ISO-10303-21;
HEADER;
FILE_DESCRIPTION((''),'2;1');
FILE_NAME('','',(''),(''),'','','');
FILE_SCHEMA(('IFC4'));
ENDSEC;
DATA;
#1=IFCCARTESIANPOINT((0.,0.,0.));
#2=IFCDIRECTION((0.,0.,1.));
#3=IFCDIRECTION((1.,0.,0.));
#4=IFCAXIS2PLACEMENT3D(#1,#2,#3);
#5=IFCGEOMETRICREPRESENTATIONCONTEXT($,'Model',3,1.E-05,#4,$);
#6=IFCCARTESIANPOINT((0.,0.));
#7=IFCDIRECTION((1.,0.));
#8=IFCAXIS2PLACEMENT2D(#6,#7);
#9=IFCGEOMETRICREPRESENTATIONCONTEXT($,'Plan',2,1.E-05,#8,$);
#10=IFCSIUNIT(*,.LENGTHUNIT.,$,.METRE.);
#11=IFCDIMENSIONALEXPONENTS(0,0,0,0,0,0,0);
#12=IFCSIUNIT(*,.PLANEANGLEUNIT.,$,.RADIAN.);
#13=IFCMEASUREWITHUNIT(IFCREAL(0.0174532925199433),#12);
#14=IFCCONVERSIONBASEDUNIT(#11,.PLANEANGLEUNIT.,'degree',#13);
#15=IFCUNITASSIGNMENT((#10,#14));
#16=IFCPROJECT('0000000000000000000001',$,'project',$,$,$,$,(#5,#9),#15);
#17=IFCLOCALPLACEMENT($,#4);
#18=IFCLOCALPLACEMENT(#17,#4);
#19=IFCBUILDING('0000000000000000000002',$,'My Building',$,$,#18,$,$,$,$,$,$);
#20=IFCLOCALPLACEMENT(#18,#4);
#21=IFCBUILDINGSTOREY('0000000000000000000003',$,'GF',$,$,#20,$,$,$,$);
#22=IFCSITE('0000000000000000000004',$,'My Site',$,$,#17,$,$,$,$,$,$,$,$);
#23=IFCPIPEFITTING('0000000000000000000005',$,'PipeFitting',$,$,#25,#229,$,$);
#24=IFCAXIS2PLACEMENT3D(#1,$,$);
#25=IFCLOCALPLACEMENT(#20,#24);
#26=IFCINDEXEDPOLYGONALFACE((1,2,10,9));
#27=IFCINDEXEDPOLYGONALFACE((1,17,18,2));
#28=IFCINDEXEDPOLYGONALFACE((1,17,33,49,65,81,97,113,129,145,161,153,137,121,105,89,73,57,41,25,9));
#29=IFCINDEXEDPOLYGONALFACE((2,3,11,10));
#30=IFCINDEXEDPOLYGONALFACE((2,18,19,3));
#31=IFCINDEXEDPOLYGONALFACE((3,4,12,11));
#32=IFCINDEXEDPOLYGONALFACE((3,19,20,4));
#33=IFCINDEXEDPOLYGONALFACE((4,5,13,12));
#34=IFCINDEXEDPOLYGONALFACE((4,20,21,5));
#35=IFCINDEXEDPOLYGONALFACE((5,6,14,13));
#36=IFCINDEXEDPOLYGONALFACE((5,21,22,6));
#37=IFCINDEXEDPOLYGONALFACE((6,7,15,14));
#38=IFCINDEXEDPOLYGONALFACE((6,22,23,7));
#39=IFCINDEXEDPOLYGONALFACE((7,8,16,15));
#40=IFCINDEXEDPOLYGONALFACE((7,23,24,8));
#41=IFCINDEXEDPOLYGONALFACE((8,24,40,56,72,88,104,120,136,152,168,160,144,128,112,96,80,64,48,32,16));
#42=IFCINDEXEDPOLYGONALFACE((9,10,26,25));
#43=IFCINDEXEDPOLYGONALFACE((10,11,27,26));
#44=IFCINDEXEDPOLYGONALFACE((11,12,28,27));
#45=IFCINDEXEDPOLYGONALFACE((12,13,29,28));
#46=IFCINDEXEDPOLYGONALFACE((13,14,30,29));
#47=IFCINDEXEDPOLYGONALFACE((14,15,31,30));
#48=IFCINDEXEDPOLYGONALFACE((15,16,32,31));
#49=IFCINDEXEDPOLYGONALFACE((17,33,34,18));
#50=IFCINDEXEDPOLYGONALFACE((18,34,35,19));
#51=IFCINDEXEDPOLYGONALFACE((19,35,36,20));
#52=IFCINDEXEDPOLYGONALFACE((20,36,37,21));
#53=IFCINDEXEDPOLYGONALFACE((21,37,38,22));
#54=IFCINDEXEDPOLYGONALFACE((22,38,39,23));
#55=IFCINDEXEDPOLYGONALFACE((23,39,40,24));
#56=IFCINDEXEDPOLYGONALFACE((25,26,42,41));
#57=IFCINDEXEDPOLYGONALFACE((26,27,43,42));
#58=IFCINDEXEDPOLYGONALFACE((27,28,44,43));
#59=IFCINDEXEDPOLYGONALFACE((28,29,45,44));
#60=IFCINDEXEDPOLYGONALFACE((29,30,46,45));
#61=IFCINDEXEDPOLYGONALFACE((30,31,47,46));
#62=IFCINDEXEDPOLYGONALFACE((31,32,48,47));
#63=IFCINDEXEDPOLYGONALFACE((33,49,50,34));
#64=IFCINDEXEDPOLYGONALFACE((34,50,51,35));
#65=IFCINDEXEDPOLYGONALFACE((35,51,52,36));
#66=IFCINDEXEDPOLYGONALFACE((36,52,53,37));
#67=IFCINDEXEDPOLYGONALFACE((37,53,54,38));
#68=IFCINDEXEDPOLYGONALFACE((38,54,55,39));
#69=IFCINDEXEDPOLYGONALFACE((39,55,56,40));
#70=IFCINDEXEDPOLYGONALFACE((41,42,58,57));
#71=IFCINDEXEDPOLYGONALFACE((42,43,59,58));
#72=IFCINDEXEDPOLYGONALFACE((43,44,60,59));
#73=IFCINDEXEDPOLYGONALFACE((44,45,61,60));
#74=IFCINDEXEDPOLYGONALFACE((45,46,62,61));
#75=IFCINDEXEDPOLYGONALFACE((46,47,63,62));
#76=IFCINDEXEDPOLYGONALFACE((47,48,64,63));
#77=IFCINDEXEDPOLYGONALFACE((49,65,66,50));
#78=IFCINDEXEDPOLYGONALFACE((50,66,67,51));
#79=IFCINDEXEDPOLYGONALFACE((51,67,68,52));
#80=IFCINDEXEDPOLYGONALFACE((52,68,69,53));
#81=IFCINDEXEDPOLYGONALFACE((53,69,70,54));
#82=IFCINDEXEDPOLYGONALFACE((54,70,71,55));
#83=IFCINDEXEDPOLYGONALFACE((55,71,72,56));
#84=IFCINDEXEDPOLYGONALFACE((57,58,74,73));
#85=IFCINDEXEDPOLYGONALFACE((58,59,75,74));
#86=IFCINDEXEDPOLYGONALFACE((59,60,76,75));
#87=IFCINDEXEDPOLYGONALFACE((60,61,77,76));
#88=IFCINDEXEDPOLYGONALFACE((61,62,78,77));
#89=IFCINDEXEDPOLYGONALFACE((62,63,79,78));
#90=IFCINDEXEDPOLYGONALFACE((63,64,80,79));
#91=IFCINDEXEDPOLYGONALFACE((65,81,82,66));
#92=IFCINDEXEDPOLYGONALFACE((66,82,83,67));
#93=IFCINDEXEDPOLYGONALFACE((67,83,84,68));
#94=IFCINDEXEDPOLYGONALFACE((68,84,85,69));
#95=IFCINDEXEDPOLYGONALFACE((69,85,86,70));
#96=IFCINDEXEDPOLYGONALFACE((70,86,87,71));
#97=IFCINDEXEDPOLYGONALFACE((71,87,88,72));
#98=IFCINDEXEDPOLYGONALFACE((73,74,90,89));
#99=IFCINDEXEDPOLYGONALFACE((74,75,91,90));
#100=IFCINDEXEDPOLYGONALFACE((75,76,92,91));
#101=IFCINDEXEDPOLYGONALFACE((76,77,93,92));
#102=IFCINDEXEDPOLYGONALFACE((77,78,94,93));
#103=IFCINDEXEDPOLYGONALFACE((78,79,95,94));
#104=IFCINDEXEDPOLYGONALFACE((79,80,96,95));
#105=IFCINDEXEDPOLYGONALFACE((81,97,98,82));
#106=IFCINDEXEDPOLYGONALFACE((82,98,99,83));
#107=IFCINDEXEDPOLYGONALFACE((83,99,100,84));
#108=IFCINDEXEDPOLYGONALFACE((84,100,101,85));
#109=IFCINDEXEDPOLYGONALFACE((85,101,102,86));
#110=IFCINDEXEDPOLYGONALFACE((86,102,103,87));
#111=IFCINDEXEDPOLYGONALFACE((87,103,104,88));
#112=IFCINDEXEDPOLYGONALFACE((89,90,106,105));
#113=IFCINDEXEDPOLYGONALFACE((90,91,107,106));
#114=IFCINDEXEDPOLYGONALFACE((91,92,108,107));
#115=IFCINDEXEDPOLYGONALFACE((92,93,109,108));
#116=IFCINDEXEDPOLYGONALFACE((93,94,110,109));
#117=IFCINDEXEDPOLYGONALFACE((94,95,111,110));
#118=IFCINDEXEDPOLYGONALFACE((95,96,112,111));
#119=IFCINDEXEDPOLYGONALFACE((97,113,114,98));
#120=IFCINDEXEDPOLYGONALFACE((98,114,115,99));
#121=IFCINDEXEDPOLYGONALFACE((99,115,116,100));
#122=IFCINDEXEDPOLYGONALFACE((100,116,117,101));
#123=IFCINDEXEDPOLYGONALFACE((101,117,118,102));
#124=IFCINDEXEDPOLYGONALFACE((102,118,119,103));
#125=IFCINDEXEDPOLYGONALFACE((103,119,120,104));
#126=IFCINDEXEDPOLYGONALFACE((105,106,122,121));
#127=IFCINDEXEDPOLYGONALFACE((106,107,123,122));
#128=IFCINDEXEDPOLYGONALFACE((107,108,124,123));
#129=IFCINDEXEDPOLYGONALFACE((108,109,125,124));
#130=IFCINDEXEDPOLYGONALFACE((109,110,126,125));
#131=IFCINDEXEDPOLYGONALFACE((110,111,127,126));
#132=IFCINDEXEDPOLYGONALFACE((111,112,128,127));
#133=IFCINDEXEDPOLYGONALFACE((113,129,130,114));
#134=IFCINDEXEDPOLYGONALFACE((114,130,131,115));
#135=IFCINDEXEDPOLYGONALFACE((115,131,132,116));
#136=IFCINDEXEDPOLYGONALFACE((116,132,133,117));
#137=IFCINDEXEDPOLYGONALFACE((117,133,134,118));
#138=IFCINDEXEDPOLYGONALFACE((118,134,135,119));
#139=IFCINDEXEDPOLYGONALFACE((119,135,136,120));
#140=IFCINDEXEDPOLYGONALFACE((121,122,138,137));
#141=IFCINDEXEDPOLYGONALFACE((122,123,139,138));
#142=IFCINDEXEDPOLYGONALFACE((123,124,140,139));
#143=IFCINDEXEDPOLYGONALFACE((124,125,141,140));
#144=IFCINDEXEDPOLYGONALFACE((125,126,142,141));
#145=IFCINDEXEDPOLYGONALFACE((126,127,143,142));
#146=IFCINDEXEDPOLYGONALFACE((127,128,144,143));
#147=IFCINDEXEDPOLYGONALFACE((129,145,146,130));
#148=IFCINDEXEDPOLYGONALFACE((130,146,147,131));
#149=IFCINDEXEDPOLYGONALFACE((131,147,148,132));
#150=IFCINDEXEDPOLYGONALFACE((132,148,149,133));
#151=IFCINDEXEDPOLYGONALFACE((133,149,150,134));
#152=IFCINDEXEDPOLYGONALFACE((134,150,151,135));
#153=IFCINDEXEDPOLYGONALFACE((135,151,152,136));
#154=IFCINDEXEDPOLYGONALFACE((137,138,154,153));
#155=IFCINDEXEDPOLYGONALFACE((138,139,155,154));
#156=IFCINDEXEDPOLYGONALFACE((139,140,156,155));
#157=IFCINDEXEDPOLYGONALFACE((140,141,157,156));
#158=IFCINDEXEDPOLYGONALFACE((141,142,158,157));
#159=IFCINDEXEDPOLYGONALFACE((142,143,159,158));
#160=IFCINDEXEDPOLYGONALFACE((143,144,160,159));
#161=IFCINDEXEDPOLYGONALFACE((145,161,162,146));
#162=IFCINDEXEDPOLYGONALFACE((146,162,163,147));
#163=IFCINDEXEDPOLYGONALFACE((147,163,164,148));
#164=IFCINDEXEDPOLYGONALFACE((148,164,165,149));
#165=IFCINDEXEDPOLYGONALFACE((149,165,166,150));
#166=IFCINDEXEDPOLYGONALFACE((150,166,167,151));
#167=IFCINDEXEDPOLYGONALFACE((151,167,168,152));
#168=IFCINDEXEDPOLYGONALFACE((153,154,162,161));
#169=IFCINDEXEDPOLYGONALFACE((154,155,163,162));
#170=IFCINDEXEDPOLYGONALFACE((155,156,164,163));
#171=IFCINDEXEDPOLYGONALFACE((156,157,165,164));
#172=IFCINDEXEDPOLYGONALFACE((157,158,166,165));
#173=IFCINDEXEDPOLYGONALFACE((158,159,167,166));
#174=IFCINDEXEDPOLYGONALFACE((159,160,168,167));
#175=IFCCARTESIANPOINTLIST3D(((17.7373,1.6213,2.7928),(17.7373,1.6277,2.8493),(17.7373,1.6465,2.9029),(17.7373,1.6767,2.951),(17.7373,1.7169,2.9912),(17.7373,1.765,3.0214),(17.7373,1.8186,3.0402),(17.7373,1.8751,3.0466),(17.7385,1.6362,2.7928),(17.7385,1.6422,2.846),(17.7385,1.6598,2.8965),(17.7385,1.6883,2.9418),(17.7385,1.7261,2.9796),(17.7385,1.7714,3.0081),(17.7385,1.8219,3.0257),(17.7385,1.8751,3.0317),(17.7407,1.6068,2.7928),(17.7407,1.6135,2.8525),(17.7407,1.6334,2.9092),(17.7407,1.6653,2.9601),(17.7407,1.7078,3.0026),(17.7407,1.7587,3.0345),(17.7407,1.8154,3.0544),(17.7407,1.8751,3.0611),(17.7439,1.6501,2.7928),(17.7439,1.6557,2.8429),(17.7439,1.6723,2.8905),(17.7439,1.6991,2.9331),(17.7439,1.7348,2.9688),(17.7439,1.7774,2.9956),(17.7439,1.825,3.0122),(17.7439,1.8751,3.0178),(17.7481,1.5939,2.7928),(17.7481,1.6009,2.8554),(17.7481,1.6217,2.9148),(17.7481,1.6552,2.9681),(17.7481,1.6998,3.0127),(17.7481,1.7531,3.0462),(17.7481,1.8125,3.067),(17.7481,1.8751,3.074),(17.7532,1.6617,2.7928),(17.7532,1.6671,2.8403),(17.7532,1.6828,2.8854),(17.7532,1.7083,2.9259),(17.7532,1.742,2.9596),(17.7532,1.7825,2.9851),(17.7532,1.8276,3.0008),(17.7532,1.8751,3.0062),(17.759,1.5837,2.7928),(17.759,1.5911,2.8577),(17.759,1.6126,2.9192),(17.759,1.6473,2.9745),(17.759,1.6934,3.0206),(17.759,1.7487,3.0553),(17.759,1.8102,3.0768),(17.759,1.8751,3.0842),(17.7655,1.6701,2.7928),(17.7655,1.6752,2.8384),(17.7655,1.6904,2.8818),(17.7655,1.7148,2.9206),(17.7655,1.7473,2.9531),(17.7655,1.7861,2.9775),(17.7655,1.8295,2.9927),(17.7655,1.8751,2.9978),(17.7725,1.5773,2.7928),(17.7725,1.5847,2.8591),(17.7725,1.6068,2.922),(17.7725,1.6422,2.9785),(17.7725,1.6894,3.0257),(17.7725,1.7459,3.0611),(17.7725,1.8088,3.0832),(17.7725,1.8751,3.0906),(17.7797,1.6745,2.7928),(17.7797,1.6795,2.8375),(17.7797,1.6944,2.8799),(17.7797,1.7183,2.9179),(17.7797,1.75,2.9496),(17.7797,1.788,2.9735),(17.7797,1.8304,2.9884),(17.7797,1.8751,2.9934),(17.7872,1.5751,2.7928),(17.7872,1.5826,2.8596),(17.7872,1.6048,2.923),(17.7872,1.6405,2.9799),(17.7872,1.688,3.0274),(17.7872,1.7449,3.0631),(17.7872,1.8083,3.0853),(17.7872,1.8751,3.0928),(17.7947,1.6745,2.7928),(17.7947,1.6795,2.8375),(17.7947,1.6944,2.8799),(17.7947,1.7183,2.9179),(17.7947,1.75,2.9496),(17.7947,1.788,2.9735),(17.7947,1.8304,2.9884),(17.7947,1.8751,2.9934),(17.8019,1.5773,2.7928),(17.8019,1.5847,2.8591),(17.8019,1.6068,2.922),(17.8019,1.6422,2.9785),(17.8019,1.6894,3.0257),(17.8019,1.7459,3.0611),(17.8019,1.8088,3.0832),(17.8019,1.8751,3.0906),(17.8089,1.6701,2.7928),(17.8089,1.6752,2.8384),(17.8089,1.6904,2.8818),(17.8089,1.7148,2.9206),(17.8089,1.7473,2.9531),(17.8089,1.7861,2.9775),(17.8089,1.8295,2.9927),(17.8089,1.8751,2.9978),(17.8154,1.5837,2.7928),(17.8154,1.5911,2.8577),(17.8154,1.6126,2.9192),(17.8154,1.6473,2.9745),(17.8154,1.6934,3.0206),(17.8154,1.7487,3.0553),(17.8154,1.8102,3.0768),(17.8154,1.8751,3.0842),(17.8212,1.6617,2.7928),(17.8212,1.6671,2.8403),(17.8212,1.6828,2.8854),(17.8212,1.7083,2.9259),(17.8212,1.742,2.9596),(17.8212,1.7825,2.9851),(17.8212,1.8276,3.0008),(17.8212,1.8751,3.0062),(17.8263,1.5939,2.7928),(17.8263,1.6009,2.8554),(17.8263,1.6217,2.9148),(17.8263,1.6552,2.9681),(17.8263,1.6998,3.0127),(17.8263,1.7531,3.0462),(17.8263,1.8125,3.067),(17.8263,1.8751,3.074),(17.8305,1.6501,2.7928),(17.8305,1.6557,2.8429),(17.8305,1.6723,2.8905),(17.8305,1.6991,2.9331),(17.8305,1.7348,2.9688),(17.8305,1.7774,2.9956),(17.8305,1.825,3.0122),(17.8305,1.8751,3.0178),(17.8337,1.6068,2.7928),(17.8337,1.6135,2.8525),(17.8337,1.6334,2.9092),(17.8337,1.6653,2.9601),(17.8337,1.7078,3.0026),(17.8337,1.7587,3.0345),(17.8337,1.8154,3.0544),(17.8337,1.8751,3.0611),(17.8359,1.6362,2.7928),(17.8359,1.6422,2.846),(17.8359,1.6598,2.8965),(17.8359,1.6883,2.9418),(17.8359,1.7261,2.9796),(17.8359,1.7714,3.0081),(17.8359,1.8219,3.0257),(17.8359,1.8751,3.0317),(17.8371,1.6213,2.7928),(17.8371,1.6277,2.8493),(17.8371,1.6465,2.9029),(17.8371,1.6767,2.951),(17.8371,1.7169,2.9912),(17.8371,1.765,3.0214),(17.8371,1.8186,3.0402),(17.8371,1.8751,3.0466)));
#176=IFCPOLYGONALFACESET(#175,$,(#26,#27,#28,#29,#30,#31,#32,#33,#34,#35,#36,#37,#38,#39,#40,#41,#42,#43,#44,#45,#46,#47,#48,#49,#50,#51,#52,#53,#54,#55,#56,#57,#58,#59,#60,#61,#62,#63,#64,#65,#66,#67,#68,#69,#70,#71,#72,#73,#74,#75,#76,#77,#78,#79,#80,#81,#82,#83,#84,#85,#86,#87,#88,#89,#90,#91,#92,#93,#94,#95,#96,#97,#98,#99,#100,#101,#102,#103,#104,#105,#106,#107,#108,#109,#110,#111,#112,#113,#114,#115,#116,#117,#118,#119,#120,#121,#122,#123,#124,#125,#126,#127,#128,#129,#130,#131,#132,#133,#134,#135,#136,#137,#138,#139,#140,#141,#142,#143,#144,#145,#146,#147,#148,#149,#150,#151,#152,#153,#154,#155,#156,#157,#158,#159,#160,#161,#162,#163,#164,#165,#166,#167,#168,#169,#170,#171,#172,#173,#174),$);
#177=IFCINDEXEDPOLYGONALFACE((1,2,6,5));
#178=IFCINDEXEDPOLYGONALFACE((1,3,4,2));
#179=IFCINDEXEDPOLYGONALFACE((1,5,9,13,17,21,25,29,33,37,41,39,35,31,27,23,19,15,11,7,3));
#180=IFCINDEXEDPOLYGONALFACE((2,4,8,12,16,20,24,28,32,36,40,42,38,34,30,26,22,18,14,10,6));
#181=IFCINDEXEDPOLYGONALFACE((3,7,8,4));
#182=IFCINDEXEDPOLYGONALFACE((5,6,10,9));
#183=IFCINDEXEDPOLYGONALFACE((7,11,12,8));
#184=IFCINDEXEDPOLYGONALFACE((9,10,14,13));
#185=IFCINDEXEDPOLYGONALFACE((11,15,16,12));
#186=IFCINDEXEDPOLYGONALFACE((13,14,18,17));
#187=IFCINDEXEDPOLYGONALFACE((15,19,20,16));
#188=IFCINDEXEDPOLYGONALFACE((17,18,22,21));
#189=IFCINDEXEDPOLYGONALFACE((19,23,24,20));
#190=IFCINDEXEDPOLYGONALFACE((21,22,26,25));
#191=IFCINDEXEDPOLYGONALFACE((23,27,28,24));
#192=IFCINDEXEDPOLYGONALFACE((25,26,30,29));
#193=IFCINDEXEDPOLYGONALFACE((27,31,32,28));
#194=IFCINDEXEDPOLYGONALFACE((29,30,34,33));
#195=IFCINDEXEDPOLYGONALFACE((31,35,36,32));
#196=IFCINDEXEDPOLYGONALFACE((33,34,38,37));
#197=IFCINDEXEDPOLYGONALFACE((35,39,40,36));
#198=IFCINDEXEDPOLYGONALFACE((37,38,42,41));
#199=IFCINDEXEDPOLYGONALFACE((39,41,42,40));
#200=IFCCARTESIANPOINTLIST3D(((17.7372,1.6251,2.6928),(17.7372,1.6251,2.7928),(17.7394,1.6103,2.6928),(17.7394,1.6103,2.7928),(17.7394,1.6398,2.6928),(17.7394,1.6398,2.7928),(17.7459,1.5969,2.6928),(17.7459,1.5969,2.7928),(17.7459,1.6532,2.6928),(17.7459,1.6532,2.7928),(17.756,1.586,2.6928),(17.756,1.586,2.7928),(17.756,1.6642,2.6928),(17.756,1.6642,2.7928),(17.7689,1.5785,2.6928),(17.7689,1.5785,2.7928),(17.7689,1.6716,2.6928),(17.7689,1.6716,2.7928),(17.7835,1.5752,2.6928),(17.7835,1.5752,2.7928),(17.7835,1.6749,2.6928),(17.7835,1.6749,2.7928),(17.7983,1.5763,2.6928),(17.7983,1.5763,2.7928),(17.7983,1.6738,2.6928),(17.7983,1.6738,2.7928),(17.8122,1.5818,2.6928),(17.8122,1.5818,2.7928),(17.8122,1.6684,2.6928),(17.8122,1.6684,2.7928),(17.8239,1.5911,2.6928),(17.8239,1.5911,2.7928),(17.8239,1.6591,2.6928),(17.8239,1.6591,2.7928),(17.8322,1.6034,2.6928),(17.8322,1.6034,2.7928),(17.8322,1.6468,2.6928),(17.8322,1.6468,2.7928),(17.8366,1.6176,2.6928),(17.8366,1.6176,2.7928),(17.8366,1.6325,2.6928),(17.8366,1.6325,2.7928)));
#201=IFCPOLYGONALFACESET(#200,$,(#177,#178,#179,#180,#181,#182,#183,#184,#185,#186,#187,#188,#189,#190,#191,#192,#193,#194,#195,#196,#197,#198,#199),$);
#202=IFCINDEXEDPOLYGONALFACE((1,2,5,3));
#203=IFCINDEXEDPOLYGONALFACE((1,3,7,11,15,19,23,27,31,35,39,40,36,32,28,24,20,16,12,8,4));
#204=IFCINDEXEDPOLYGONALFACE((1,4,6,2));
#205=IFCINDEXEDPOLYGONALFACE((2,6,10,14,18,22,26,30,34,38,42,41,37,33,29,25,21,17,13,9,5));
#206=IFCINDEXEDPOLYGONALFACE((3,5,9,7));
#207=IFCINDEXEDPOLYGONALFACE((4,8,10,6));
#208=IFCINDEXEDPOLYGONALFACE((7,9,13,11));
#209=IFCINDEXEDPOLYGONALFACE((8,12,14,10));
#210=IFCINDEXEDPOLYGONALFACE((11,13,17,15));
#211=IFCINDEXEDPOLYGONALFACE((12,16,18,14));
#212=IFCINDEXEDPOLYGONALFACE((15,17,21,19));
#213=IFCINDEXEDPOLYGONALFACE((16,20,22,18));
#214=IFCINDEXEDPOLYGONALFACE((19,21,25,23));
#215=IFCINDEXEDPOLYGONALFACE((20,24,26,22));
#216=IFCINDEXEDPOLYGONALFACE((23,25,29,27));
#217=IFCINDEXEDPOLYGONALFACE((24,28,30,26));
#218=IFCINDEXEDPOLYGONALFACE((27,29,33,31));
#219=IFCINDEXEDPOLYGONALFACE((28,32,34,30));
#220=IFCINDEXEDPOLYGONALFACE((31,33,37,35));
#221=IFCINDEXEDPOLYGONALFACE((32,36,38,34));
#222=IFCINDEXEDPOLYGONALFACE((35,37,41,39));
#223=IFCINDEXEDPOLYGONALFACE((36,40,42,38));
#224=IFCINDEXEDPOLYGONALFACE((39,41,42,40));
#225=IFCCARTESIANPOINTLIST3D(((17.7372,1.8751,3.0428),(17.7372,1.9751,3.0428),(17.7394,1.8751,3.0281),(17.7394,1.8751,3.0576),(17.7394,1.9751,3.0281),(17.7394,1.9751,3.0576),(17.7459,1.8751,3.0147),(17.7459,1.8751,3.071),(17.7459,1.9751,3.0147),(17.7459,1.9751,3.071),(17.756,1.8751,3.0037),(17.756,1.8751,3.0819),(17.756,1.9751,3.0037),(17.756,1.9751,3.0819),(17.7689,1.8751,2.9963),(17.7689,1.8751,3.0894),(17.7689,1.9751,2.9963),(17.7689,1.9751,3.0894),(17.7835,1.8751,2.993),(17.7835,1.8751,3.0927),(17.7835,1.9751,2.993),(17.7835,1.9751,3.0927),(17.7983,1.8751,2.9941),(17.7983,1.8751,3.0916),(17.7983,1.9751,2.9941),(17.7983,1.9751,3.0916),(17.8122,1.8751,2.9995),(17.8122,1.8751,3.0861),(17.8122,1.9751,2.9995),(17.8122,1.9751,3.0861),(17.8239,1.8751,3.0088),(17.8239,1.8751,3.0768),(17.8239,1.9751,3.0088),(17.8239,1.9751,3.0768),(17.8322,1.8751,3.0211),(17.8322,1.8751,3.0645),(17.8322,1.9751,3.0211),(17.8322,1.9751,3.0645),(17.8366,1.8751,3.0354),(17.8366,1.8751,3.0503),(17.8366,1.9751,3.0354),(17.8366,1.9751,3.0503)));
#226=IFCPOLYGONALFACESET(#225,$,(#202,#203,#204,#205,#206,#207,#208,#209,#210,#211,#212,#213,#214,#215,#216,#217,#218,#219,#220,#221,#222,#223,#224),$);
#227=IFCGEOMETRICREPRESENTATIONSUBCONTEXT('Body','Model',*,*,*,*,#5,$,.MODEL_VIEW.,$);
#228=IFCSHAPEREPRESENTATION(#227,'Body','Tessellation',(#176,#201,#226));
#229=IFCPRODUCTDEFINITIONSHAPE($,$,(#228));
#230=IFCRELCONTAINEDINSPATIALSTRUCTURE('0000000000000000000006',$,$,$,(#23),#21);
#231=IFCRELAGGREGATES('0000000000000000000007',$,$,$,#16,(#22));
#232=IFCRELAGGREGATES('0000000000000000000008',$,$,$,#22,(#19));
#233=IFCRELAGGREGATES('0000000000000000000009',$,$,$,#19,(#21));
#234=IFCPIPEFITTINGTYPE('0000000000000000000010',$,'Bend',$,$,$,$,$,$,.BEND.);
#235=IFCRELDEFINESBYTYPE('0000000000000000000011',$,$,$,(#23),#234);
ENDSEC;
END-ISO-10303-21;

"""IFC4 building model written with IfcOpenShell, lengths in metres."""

from ifc_helpers import new_model, entity, si_unit, converted_unit, frame, origin_with_axes, origin_2d_with_axis, place, context, subcontext, project, spatial, line, indexed_curve, circle, outline, extrude, source, transform, mapped, type_object, type_shapes, element, save


model = new_model("IFC4")

# Units and contexts
model_context = context("Model", 3, precision=1e-05, world=origin_with_axes())
plan_context = context("Plan", 2, precision=1e-05, world=origin_2d_with_axis())
body_context_1 = subcontext(model_context, "Body", "Model", "MODEL_VIEW")
ifc_project = project(units=[si_unit("LENGTHUNIT", "METRE"), converted_unit("PLANEANGLEUNIT", "degree", entity("IfcReal", 0.0174532925199433), si_unit("PLANEANGLEUNIT", "RADIAN"), dimensions=[0, 0, 0, 0, 0, 0, 0])], contexts=[model_context, plan_context])

# Site, building, storey
site_placement = place(None, origin_with_axes())
site = spatial("IfcSite", under=ifc_project, at=site_placement, Name="My Site")
building_placement = place(site_placement, origin_with_axes())
building = spatial("IfcBuilding", under=site, at=building_placement, Name="My Building")
storey_placement = place(building_placement, origin_with_axes())
storey = spatial("IfcBuildingStorey", under=building, at=storey_placement, Name="GF")

# Pipe fitting, opening
pipe_fitting_type = type_object("IfcPipeFittingType", Name="Bend", PredefinedType="BEND")
shared_shape_1 = source(origin_with_axes(), body_context_1, "Body", "SolidModel", [
    entity("IfcSweptDiskSolid", entity("IfcIndexedPolyCurve", entity("IfcCartesianPointList3D", [[0.0, 0.0, 0.1], [0.0, -0.0732, 0.2768], [0.0, -0.25, 0.35]]), [entity("IfcArcIndex", [1, 2, 3])]), 0.05),
    extrude(circle(Radius=0.05), origin_with_axes(), (0.0, 0.0, 1.0), 0.1),
    extrude(circle(Radius=0.05), frame((0.0, -0.25, 0.35), z_axis=(0.0, -1.0, 0.0), x_axis=(1.0, 0.0, 0.0)), (0.0, 0.0, 1.0), 0.1),
])
type_shapes(pipe_fitting_type, [shared_shape_1])
pipe_fitting_1_placement = place(storey_placement, frame((17.7872, 1.6251, 2.6928), z_axis=(0.0, 0.0, 1.0), x_axis=(-1.0, 0.0, 0.0)))
pipe_fitting_1 = element("IfcPipeFitting", 1, at=pipe_fitting_1_placement, inside=storey, type_object=pipe_fitting_type, Name="PipeFitting", context=body_context_1, shape_type="MappedRepresentation", body=[
    mapped(shared_shape_1, transform((0.0, 0.0, 0.0), x_axis=(1.0, 0.0, 0.0), y_axis=(0.0, 1.0, 0.0), z_axis=(0.0, 0.0, 1.0), scale=1.0)),
])
opening_1_placement = place(pipe_fitting_1_placement, frame((17.7872, 1.6251, -2.6928), z_axis=(0.0, 0.0, 1.0), x_axis=(-1.0, 0.0, 0.0)))
element("IfcOpeningElement", 2, at=opening_1_placement, cuts=pipe_fitting_1, PredefinedType="OPENING", context=body_context_1, shape_type="SweptSolid", body=[
    extrude(outline(indexed_curve([(0.0, 0.0), (0.5, 0.0), (0.5, 0.5), (0.0, 0.5)], segments=[line(1, 2, 3, 4, 1)])), origin_with_axes(), (0.0, 0.0, 1.0), 0.5),
])

save(model, "model.ifc")
